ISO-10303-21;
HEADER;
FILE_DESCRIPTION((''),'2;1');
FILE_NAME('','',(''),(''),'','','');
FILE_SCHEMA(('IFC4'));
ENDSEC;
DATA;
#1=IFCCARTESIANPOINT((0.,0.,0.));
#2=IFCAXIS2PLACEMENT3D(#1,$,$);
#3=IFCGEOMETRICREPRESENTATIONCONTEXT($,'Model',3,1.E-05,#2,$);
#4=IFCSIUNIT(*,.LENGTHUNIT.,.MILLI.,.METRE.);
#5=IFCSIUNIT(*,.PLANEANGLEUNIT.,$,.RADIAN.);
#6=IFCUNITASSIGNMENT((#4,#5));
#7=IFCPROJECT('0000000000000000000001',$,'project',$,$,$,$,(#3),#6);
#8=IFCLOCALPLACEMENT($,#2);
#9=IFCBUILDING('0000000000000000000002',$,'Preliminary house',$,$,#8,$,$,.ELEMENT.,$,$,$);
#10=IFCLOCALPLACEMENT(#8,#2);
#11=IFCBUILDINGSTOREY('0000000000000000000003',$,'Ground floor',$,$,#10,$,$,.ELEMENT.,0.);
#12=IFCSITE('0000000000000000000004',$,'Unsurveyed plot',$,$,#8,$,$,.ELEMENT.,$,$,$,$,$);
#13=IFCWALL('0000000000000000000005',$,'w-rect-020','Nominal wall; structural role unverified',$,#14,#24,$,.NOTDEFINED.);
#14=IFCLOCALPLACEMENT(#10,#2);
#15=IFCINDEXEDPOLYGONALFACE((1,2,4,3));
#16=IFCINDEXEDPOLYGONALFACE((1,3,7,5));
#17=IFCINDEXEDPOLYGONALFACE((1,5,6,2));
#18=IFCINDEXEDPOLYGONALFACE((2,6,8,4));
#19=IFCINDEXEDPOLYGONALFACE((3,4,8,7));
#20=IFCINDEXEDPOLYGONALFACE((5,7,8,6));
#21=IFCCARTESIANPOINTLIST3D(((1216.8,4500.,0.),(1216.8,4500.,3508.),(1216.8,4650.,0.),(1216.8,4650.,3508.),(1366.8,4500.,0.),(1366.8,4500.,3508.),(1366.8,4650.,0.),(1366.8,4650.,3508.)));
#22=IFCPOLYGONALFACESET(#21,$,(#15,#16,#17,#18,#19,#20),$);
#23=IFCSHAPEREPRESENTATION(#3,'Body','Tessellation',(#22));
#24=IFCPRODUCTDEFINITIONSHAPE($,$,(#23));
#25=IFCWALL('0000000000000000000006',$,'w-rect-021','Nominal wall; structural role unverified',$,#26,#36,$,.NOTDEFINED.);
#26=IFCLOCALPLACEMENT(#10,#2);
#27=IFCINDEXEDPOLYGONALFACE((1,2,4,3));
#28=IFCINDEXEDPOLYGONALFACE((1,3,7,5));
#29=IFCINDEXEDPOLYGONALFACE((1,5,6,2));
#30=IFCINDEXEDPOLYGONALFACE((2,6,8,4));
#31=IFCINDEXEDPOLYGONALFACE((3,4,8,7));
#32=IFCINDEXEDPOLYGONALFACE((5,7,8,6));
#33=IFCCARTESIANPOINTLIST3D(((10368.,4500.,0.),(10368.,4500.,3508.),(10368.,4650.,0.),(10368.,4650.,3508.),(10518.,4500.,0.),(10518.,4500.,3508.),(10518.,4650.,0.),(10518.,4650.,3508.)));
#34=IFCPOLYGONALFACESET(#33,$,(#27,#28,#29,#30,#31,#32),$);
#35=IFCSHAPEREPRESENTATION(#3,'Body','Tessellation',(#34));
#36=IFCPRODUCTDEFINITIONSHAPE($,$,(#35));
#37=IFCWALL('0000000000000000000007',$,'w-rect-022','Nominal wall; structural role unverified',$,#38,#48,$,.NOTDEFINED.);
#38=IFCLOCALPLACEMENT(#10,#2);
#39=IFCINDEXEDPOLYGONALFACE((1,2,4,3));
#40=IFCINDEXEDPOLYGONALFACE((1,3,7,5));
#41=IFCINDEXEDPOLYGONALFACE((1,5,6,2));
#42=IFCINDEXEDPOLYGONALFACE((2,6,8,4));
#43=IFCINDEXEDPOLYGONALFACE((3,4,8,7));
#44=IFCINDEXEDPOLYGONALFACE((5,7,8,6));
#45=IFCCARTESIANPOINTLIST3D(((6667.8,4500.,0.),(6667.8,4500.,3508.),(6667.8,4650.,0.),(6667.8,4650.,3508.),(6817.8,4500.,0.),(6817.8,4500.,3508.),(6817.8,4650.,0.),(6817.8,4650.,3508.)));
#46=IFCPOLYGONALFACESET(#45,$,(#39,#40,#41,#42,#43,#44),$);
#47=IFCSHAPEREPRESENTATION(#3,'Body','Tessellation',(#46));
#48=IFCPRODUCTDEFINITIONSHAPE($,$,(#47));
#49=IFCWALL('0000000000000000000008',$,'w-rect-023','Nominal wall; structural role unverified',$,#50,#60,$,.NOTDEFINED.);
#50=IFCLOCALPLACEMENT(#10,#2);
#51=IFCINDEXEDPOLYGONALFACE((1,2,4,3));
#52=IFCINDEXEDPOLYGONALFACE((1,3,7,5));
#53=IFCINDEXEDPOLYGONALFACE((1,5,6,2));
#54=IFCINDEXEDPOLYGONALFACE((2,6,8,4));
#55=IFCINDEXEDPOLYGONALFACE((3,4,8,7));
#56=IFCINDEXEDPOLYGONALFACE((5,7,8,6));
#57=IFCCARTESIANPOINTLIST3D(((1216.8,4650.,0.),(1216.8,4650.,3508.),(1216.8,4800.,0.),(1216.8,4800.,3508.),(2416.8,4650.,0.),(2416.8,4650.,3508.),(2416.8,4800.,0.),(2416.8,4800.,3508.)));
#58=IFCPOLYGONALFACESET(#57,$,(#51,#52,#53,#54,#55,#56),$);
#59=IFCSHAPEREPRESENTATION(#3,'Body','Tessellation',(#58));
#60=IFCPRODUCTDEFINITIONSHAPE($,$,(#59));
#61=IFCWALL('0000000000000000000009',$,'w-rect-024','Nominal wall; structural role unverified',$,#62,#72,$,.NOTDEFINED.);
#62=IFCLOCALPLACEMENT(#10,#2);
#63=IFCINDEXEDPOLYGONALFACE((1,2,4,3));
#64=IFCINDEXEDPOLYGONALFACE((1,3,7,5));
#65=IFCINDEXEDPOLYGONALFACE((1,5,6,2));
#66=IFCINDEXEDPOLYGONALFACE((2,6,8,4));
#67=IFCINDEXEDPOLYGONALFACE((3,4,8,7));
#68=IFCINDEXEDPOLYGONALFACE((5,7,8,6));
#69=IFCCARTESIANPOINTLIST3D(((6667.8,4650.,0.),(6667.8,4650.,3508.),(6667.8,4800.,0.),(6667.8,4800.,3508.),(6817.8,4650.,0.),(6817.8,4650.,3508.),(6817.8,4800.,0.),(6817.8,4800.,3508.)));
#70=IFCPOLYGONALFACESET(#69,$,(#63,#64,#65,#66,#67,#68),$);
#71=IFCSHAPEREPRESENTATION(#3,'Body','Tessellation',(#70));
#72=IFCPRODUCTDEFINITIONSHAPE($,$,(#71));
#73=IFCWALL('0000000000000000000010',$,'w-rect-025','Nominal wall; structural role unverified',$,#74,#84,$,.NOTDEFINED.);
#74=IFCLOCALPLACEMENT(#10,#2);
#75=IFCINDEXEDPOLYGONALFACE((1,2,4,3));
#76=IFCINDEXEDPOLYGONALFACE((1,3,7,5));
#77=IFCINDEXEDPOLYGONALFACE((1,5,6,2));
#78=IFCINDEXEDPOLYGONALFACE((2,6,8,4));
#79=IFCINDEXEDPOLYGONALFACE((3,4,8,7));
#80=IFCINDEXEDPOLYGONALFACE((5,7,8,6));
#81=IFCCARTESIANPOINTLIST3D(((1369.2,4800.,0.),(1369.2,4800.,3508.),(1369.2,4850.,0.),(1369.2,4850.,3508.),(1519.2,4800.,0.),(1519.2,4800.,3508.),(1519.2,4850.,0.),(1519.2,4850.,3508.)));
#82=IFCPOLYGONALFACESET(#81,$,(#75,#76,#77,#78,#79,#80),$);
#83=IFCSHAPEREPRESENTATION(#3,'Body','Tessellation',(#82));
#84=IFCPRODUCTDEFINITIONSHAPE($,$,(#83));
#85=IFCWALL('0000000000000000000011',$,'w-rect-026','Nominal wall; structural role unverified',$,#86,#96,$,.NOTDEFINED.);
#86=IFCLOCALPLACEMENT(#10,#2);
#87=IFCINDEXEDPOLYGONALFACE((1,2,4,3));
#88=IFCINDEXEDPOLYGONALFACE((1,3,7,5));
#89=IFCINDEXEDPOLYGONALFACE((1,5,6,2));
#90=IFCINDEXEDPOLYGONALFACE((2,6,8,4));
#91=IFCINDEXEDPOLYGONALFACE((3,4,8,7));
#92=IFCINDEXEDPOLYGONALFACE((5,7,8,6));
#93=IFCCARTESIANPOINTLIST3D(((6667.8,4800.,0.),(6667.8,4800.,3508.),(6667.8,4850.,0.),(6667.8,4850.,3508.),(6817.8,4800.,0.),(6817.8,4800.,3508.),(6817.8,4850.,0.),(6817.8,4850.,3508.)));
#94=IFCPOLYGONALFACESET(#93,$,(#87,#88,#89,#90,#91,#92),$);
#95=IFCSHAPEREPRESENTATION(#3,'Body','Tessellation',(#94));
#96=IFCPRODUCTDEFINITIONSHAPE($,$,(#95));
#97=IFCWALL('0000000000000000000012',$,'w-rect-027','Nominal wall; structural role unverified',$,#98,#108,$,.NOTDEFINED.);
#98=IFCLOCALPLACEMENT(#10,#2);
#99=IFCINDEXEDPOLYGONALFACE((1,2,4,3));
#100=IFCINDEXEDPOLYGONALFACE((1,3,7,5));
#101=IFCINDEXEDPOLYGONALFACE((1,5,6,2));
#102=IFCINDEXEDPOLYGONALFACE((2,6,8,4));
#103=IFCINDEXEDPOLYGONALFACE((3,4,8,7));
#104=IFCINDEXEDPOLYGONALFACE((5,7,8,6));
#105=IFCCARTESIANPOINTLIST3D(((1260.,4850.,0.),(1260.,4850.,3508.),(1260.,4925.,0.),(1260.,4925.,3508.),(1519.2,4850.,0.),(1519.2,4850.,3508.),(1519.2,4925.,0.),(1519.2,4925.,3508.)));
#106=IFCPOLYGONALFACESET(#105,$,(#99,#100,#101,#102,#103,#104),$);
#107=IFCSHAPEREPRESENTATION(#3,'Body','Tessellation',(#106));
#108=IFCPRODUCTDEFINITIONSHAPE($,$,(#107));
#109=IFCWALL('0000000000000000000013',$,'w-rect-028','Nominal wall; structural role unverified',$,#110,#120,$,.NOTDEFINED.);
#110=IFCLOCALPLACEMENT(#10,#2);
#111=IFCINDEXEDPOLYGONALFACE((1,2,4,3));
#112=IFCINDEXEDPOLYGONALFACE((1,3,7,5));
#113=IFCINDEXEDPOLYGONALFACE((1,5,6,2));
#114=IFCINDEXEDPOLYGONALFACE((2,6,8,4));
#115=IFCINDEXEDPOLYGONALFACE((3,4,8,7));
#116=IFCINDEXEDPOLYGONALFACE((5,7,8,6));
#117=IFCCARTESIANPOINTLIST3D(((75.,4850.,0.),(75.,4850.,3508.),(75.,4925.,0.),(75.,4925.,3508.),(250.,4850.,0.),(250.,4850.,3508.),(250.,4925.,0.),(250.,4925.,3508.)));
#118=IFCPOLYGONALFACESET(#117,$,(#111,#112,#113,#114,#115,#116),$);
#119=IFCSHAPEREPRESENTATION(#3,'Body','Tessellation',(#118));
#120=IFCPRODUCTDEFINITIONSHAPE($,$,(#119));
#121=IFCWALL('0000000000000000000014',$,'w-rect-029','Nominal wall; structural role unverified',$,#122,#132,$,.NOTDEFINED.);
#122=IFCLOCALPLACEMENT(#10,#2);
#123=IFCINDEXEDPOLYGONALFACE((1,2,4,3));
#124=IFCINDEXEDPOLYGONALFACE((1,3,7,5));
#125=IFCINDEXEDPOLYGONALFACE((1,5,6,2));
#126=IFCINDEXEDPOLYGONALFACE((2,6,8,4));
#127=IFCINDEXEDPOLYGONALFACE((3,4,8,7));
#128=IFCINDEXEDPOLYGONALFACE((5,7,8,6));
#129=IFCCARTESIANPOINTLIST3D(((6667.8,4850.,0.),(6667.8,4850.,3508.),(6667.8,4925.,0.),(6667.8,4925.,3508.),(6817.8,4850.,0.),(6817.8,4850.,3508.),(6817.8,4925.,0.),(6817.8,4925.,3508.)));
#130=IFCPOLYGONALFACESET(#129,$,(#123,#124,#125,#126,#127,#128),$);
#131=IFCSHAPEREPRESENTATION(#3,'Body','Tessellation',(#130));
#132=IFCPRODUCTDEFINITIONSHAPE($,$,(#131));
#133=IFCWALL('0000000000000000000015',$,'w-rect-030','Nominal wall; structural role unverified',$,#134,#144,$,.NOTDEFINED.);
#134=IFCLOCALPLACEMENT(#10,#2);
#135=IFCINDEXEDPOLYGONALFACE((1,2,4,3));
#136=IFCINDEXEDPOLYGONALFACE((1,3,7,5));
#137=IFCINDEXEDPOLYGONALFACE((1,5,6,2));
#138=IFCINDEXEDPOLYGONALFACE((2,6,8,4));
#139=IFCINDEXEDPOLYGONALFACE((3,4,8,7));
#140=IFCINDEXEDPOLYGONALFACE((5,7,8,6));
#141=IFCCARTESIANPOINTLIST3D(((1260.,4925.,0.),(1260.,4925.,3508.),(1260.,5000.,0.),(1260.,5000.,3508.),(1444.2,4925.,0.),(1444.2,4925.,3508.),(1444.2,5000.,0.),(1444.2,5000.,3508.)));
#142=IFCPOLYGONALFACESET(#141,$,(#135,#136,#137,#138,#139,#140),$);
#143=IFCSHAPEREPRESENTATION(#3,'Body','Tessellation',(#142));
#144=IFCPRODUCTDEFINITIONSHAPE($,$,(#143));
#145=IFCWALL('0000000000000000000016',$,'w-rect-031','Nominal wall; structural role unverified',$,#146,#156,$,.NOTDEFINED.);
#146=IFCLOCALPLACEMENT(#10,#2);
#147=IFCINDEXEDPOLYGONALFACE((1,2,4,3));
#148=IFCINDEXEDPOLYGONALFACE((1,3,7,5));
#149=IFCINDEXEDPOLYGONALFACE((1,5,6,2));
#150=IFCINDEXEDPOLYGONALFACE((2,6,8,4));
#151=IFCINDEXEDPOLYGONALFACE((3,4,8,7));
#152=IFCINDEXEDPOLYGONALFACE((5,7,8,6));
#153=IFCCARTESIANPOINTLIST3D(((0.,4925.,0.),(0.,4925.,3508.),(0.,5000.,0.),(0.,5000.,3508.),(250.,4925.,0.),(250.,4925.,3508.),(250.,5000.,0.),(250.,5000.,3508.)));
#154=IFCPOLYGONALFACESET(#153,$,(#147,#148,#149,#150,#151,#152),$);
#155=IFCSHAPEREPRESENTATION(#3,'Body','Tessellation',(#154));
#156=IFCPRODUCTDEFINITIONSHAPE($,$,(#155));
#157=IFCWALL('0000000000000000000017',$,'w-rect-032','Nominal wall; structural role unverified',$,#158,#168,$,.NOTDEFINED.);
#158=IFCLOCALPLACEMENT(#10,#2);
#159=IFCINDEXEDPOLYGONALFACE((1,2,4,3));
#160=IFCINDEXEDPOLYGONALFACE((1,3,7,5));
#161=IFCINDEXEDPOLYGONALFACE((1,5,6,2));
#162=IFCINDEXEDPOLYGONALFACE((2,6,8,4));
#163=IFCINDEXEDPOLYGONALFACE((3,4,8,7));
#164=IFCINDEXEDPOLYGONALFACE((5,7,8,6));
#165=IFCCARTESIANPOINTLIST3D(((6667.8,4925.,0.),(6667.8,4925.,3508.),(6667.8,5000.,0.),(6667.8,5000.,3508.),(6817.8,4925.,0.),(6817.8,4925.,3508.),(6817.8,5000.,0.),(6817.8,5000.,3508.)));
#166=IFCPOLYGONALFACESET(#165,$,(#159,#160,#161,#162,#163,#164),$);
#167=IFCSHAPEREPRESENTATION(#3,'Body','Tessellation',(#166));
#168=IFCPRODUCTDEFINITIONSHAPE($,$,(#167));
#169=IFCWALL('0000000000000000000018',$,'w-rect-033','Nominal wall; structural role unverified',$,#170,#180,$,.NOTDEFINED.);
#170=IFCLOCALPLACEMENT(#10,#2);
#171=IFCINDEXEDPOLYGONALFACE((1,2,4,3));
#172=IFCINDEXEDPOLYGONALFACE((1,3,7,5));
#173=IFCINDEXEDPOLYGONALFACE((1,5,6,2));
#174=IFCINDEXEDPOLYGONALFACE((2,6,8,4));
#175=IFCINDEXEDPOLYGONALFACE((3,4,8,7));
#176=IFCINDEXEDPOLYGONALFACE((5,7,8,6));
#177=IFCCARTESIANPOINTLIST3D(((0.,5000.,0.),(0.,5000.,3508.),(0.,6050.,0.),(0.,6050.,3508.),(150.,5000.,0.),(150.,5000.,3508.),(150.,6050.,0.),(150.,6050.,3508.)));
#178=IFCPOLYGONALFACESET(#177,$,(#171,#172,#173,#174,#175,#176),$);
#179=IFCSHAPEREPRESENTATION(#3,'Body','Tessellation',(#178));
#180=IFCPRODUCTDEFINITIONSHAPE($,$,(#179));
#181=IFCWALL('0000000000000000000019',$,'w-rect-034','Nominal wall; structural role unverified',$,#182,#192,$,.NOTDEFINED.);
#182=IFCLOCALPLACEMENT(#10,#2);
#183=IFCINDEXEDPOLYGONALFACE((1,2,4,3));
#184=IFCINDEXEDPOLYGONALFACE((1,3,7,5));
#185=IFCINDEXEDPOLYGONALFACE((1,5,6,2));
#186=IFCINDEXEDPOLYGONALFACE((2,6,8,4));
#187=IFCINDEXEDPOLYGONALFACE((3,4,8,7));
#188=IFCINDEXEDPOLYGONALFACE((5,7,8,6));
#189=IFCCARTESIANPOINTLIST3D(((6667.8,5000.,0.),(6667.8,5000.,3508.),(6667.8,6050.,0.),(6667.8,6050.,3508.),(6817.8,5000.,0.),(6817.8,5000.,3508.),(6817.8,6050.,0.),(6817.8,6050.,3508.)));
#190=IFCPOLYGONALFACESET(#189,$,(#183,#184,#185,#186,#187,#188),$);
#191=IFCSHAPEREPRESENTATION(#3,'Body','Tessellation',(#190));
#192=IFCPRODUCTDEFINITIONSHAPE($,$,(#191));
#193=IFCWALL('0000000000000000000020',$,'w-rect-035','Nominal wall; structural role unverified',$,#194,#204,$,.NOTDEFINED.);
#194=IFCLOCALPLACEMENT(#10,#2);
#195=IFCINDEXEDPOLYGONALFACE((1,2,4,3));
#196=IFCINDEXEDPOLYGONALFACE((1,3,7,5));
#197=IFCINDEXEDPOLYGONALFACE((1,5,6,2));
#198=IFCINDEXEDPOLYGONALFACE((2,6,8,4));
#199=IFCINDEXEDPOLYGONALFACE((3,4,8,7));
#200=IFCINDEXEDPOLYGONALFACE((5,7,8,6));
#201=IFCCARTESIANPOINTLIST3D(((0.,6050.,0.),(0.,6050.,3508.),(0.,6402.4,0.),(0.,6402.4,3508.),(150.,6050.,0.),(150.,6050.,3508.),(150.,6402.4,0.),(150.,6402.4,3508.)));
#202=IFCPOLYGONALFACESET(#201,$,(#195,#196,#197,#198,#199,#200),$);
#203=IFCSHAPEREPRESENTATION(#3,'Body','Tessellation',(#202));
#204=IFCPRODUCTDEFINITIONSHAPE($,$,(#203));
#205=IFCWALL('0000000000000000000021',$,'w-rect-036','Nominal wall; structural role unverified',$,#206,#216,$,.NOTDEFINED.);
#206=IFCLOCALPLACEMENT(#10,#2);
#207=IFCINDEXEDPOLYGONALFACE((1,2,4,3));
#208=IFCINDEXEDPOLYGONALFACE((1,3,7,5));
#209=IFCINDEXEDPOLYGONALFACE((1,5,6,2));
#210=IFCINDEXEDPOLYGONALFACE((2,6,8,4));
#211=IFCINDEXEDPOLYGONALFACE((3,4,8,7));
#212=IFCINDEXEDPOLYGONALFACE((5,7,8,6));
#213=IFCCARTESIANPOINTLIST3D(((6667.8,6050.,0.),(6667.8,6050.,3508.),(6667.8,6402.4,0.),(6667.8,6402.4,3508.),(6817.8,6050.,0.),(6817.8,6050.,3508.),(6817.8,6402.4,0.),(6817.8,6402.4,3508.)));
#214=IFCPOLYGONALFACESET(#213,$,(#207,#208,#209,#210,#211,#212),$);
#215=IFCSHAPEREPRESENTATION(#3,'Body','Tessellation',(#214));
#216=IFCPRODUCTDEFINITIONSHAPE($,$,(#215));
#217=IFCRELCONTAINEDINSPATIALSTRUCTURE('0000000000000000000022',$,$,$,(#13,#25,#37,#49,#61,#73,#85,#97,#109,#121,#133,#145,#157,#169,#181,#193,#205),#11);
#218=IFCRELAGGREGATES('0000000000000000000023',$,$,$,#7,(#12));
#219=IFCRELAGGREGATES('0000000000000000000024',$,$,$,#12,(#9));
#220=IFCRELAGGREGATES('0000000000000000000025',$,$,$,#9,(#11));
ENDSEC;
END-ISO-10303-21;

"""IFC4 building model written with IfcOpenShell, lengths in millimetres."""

from ifc_helpers import new_model, si_unit, origin, place, context, project, spatial, polyline, outline, extrude, element, save


model = new_model("IFC4")

# Units and contexts
model_context = context("Model", 3, precision=1e-05, world=origin())
ifc_project = project(units=[si_unit("LENGTHUNIT", "METRE", prefix="MILLI"), si_unit("PLANEANGLEUNIT", "RADIAN")], contexts=[model_context])

# Site, building, storey
placement_1 = place(None, origin())
site = spatial("IfcSite", under=ifc_project, at=placement_1, Name="Unsurveyed plot", CompositionType="ELEMENT")
building = spatial("IfcBuilding", under=site, at=placement_1, Name="Preliminary house", CompositionType="ELEMENT")
placement_2 = place(placement_1, origin())
storey = spatial("IfcBuildingStorey", under=building, at=placement_2, Name="Ground floor", CompositionType="ELEMENT", Elevation=0.0)

# Walls
element("IfcWall", 1, at=placement_2, inside=storey, Name="w-rect-020", Description="Nominal wall; structural role unverified", PredefinedType="NOTDEFINED", context=model_context, shape_type="SweptSolid", body=[
    extrude(outline(polyline([(1216.8, 4500.0), (1366.8, 4500.0), (1366.8, 4650.0), (1216.8, 4650.0), (1216.8, 4500.0)])), origin(), (0.0, 0.0, 1.0), 3508.0),
])
element("IfcWall", 2, at=placement_2, inside=storey, Name="w-rect-021", Description="Nominal wall; structural role unverified", PredefinedType="NOTDEFINED", context=model_context, shape_type="SweptSolid", body=[
    extrude(outline(polyline([(10368.0, 4500.0), (10518.0, 4500.0), (10518.0, 4650.0), (10368.0, 4650.0), (10368.0, 4500.0)])), origin(), (0.0, 0.0, 1.0), 3508.0),
])
element("IfcWall", 3, at=placement_2, inside=storey, Name="w-rect-022", Description="Nominal wall; structural role unverified", PredefinedType="NOTDEFINED", context=model_context, shape_type="SweptSolid", body=[
    extrude(outline(polyline([(6667.8, 4500.0), (6817.8, 4500.0), (6817.8, 4650.0), (6667.8, 4650.0), (6667.8, 4500.0)])), origin(), (0.0, 0.0, 1.0), 3508.0),
])
element("IfcWall", 4, at=placement_2, inside=storey, Name="w-rect-023", Description="Nominal wall; structural role unverified", PredefinedType="NOTDEFINED", context=model_context, shape_type="SweptSolid", body=[
    extrude(outline(polyline([(1216.8, 4650.0), (2416.8, 4650.0), (2416.8, 4800.0), (1216.8, 4800.0), (1216.8, 4650.0)])), origin(), (0.0, 0.0, 1.0), 3508.0),
])
element("IfcWall", 5, at=placement_2, inside=storey, Name="w-rect-024", Description="Nominal wall; structural role unverified", PredefinedType="NOTDEFINED", context=model_context, shape_type="SweptSolid", body=[
    extrude(outline(polyline([(6667.8, 4650.0), (6817.8, 4650.0), (6817.8, 4800.0), (6667.8, 4800.0), (6667.8, 4650.0)])), origin(), (0.0, 0.0, 1.0), 3508.0),
])
element("IfcWall", 6, at=placement_2, inside=storey, Name="w-rect-025", Description="Nominal wall; structural role unverified", PredefinedType="NOTDEFINED", context=model_context, shape_type="SweptSolid", body=[
    extrude(outline(polyline([(1369.2, 4800.0), (1519.2, 4800.0), (1519.2, 4850.0), (1369.2, 4850.0), (1369.2, 4800.0)])), origin(), (0.0, 0.0, 1.0), 3508.0),
])
element("IfcWall", 7, at=placement_2, inside=storey, Name="w-rect-026", Description="Nominal wall; structural role unverified", PredefinedType="NOTDEFINED", context=model_context, shape_type="SweptSolid", body=[
    extrude(outline(polyline([(6667.8, 4800.0), (6817.8, 4800.0), (6817.8, 4850.0), (6667.8, 4850.0), (6667.8, 4800.0)])), origin(), (0.0, 0.0, 1.0), 3508.0),
])
element("IfcWall", 8, at=placement_2, inside=storey, Name="w-rect-027", Description="Nominal wall; structural role unverified", PredefinedType="NOTDEFINED", context=model_context, shape_type="SweptSolid", body=[
    extrude(outline(polyline([(1260.0, 4850.0), (1519.2, 4850.0), (1519.2, 4925.0), (1260.0, 4925.0), (1260.0, 4850.0)])), origin(), (0.0, 0.0, 1.0), 3508.0),
])
element("IfcWall", 9, at=placement_2, inside=storey, Name="w-rect-028", Description="Nominal wall; structural role unverified", PredefinedType="NOTDEFINED", context=model_context, shape_type="SweptSolid", body=[
    extrude(outline(polyline([(75.0, 4850.0), (250.0, 4850.0), (250.0, 4925.0), (75.0, 4925.0), (75.0, 4850.0)])), origin(), (0.0, 0.0, 1.0), 3508.0),
])
element("IfcWall", 10, at=placement_2, inside=storey, Name="w-rect-029", Description="Nominal wall; structural role unverified", PredefinedType="NOTDEFINED", context=model_context, shape_type="SweptSolid", body=[
    extrude(outline(polyline([(6667.8, 4850.0), (6817.8, 4850.0), (6817.8, 4925.0), (6667.8, 4925.0), (6667.8, 4850.0)])), origin(), (0.0, 0.0, 1.0), 3508.0),
])
element("IfcWall", 11, at=placement_2, inside=storey, Name="w-rect-030", Description="Nominal wall; structural role unverified", PredefinedType="NOTDEFINED", context=model_context, shape_type="SweptSolid", body=[
    extrude(outline(polyline([(1260.0, 4925.0), (1444.2, 4925.0), (1444.2, 5000.0), (1260.0, 5000.0), (1260.0, 4925.0)])), origin(), (0.0, 0.0, 1.0), 3508.0),
])
element("IfcWall", 12, at=placement_2, inside=storey, Name="w-rect-031", Description="Nominal wall; structural role unverified", PredefinedType="NOTDEFINED", context=model_context, shape_type="SweptSolid", body=[
    extrude(outline(polyline([(0.0, 4925.0), (250.0, 4925.0), (250.0, 5000.0), (0.0, 5000.0), (0.0, 4925.0)])), origin(), (0.0, 0.0, 1.0), 3508.0),
])
element("IfcWall", 13, at=placement_2, inside=storey, Name="w-rect-032", Description="Nominal wall; structural role unverified", PredefinedType="NOTDEFINED", context=model_context, shape_type="SweptSolid", body=[
    extrude(outline(polyline([(6667.8, 4925.0), (6817.8, 4925.0), (6817.8, 5000.0), (6667.8, 5000.0), (6667.8, 4925.0)])), origin(), (0.0, 0.0, 1.0), 3508.0),
])
element("IfcWall", 14, at=placement_2, inside=storey, Name="w-rect-033", Description="Nominal wall; structural role unverified", PredefinedType="NOTDEFINED", context=model_context, shape_type="SweptSolid", body=[
    extrude(outline(polyline([(0.0, 5000.0), (150.0, 5000.0), (150.0, 6050.0), (0.0, 6050.0), (0.0, 5000.0)])), origin(), (0.0, 0.0, 1.0), 3508.0),
])
element("IfcWall", 15, at=placement_2, inside=storey, Name="w-rect-034", Description="Nominal wall; structural role unverified", PredefinedType="NOTDEFINED", context=model_context, shape_type="SweptSolid", body=[
    extrude(outline(polyline([(6667.8, 5000.0), (6817.8, 5000.0), (6817.8, 6050.0), (6667.8, 6050.0), (6667.8, 5000.0)])), origin(), (0.0, 0.0, 1.0), 3508.0),
])
element("IfcWall", 16, at=placement_2, inside=storey, Name="w-rect-035", Description="Nominal wall; structural role unverified", PredefinedType="NOTDEFINED", context=model_context, shape_type="SweptSolid", body=[
    extrude(outline(polyline([(0.0, 6050.0), (150.0, 6050.0), (150.0, 6402.4), (0.0, 6402.4), (0.0, 6050.0)])), origin(), (0.0, 0.0, 1.0), 3508.0),
])
element("IfcWall", 17, at=placement_2, inside=storey, Name="w-rect-036", Description="Nominal wall; structural role unverified", PredefinedType="NOTDEFINED", context=model_context, shape_type="SweptSolid", body=[
    extrude(outline(polyline([(6667.8, 6050.0), (6817.8, 6050.0), (6817.8, 6402.4), (6667.8, 6402.4), (6667.8, 6050.0)])), origin(), (0.0, 0.0, 1.0), 3508.0),
])

save(model, "model.ifc")
